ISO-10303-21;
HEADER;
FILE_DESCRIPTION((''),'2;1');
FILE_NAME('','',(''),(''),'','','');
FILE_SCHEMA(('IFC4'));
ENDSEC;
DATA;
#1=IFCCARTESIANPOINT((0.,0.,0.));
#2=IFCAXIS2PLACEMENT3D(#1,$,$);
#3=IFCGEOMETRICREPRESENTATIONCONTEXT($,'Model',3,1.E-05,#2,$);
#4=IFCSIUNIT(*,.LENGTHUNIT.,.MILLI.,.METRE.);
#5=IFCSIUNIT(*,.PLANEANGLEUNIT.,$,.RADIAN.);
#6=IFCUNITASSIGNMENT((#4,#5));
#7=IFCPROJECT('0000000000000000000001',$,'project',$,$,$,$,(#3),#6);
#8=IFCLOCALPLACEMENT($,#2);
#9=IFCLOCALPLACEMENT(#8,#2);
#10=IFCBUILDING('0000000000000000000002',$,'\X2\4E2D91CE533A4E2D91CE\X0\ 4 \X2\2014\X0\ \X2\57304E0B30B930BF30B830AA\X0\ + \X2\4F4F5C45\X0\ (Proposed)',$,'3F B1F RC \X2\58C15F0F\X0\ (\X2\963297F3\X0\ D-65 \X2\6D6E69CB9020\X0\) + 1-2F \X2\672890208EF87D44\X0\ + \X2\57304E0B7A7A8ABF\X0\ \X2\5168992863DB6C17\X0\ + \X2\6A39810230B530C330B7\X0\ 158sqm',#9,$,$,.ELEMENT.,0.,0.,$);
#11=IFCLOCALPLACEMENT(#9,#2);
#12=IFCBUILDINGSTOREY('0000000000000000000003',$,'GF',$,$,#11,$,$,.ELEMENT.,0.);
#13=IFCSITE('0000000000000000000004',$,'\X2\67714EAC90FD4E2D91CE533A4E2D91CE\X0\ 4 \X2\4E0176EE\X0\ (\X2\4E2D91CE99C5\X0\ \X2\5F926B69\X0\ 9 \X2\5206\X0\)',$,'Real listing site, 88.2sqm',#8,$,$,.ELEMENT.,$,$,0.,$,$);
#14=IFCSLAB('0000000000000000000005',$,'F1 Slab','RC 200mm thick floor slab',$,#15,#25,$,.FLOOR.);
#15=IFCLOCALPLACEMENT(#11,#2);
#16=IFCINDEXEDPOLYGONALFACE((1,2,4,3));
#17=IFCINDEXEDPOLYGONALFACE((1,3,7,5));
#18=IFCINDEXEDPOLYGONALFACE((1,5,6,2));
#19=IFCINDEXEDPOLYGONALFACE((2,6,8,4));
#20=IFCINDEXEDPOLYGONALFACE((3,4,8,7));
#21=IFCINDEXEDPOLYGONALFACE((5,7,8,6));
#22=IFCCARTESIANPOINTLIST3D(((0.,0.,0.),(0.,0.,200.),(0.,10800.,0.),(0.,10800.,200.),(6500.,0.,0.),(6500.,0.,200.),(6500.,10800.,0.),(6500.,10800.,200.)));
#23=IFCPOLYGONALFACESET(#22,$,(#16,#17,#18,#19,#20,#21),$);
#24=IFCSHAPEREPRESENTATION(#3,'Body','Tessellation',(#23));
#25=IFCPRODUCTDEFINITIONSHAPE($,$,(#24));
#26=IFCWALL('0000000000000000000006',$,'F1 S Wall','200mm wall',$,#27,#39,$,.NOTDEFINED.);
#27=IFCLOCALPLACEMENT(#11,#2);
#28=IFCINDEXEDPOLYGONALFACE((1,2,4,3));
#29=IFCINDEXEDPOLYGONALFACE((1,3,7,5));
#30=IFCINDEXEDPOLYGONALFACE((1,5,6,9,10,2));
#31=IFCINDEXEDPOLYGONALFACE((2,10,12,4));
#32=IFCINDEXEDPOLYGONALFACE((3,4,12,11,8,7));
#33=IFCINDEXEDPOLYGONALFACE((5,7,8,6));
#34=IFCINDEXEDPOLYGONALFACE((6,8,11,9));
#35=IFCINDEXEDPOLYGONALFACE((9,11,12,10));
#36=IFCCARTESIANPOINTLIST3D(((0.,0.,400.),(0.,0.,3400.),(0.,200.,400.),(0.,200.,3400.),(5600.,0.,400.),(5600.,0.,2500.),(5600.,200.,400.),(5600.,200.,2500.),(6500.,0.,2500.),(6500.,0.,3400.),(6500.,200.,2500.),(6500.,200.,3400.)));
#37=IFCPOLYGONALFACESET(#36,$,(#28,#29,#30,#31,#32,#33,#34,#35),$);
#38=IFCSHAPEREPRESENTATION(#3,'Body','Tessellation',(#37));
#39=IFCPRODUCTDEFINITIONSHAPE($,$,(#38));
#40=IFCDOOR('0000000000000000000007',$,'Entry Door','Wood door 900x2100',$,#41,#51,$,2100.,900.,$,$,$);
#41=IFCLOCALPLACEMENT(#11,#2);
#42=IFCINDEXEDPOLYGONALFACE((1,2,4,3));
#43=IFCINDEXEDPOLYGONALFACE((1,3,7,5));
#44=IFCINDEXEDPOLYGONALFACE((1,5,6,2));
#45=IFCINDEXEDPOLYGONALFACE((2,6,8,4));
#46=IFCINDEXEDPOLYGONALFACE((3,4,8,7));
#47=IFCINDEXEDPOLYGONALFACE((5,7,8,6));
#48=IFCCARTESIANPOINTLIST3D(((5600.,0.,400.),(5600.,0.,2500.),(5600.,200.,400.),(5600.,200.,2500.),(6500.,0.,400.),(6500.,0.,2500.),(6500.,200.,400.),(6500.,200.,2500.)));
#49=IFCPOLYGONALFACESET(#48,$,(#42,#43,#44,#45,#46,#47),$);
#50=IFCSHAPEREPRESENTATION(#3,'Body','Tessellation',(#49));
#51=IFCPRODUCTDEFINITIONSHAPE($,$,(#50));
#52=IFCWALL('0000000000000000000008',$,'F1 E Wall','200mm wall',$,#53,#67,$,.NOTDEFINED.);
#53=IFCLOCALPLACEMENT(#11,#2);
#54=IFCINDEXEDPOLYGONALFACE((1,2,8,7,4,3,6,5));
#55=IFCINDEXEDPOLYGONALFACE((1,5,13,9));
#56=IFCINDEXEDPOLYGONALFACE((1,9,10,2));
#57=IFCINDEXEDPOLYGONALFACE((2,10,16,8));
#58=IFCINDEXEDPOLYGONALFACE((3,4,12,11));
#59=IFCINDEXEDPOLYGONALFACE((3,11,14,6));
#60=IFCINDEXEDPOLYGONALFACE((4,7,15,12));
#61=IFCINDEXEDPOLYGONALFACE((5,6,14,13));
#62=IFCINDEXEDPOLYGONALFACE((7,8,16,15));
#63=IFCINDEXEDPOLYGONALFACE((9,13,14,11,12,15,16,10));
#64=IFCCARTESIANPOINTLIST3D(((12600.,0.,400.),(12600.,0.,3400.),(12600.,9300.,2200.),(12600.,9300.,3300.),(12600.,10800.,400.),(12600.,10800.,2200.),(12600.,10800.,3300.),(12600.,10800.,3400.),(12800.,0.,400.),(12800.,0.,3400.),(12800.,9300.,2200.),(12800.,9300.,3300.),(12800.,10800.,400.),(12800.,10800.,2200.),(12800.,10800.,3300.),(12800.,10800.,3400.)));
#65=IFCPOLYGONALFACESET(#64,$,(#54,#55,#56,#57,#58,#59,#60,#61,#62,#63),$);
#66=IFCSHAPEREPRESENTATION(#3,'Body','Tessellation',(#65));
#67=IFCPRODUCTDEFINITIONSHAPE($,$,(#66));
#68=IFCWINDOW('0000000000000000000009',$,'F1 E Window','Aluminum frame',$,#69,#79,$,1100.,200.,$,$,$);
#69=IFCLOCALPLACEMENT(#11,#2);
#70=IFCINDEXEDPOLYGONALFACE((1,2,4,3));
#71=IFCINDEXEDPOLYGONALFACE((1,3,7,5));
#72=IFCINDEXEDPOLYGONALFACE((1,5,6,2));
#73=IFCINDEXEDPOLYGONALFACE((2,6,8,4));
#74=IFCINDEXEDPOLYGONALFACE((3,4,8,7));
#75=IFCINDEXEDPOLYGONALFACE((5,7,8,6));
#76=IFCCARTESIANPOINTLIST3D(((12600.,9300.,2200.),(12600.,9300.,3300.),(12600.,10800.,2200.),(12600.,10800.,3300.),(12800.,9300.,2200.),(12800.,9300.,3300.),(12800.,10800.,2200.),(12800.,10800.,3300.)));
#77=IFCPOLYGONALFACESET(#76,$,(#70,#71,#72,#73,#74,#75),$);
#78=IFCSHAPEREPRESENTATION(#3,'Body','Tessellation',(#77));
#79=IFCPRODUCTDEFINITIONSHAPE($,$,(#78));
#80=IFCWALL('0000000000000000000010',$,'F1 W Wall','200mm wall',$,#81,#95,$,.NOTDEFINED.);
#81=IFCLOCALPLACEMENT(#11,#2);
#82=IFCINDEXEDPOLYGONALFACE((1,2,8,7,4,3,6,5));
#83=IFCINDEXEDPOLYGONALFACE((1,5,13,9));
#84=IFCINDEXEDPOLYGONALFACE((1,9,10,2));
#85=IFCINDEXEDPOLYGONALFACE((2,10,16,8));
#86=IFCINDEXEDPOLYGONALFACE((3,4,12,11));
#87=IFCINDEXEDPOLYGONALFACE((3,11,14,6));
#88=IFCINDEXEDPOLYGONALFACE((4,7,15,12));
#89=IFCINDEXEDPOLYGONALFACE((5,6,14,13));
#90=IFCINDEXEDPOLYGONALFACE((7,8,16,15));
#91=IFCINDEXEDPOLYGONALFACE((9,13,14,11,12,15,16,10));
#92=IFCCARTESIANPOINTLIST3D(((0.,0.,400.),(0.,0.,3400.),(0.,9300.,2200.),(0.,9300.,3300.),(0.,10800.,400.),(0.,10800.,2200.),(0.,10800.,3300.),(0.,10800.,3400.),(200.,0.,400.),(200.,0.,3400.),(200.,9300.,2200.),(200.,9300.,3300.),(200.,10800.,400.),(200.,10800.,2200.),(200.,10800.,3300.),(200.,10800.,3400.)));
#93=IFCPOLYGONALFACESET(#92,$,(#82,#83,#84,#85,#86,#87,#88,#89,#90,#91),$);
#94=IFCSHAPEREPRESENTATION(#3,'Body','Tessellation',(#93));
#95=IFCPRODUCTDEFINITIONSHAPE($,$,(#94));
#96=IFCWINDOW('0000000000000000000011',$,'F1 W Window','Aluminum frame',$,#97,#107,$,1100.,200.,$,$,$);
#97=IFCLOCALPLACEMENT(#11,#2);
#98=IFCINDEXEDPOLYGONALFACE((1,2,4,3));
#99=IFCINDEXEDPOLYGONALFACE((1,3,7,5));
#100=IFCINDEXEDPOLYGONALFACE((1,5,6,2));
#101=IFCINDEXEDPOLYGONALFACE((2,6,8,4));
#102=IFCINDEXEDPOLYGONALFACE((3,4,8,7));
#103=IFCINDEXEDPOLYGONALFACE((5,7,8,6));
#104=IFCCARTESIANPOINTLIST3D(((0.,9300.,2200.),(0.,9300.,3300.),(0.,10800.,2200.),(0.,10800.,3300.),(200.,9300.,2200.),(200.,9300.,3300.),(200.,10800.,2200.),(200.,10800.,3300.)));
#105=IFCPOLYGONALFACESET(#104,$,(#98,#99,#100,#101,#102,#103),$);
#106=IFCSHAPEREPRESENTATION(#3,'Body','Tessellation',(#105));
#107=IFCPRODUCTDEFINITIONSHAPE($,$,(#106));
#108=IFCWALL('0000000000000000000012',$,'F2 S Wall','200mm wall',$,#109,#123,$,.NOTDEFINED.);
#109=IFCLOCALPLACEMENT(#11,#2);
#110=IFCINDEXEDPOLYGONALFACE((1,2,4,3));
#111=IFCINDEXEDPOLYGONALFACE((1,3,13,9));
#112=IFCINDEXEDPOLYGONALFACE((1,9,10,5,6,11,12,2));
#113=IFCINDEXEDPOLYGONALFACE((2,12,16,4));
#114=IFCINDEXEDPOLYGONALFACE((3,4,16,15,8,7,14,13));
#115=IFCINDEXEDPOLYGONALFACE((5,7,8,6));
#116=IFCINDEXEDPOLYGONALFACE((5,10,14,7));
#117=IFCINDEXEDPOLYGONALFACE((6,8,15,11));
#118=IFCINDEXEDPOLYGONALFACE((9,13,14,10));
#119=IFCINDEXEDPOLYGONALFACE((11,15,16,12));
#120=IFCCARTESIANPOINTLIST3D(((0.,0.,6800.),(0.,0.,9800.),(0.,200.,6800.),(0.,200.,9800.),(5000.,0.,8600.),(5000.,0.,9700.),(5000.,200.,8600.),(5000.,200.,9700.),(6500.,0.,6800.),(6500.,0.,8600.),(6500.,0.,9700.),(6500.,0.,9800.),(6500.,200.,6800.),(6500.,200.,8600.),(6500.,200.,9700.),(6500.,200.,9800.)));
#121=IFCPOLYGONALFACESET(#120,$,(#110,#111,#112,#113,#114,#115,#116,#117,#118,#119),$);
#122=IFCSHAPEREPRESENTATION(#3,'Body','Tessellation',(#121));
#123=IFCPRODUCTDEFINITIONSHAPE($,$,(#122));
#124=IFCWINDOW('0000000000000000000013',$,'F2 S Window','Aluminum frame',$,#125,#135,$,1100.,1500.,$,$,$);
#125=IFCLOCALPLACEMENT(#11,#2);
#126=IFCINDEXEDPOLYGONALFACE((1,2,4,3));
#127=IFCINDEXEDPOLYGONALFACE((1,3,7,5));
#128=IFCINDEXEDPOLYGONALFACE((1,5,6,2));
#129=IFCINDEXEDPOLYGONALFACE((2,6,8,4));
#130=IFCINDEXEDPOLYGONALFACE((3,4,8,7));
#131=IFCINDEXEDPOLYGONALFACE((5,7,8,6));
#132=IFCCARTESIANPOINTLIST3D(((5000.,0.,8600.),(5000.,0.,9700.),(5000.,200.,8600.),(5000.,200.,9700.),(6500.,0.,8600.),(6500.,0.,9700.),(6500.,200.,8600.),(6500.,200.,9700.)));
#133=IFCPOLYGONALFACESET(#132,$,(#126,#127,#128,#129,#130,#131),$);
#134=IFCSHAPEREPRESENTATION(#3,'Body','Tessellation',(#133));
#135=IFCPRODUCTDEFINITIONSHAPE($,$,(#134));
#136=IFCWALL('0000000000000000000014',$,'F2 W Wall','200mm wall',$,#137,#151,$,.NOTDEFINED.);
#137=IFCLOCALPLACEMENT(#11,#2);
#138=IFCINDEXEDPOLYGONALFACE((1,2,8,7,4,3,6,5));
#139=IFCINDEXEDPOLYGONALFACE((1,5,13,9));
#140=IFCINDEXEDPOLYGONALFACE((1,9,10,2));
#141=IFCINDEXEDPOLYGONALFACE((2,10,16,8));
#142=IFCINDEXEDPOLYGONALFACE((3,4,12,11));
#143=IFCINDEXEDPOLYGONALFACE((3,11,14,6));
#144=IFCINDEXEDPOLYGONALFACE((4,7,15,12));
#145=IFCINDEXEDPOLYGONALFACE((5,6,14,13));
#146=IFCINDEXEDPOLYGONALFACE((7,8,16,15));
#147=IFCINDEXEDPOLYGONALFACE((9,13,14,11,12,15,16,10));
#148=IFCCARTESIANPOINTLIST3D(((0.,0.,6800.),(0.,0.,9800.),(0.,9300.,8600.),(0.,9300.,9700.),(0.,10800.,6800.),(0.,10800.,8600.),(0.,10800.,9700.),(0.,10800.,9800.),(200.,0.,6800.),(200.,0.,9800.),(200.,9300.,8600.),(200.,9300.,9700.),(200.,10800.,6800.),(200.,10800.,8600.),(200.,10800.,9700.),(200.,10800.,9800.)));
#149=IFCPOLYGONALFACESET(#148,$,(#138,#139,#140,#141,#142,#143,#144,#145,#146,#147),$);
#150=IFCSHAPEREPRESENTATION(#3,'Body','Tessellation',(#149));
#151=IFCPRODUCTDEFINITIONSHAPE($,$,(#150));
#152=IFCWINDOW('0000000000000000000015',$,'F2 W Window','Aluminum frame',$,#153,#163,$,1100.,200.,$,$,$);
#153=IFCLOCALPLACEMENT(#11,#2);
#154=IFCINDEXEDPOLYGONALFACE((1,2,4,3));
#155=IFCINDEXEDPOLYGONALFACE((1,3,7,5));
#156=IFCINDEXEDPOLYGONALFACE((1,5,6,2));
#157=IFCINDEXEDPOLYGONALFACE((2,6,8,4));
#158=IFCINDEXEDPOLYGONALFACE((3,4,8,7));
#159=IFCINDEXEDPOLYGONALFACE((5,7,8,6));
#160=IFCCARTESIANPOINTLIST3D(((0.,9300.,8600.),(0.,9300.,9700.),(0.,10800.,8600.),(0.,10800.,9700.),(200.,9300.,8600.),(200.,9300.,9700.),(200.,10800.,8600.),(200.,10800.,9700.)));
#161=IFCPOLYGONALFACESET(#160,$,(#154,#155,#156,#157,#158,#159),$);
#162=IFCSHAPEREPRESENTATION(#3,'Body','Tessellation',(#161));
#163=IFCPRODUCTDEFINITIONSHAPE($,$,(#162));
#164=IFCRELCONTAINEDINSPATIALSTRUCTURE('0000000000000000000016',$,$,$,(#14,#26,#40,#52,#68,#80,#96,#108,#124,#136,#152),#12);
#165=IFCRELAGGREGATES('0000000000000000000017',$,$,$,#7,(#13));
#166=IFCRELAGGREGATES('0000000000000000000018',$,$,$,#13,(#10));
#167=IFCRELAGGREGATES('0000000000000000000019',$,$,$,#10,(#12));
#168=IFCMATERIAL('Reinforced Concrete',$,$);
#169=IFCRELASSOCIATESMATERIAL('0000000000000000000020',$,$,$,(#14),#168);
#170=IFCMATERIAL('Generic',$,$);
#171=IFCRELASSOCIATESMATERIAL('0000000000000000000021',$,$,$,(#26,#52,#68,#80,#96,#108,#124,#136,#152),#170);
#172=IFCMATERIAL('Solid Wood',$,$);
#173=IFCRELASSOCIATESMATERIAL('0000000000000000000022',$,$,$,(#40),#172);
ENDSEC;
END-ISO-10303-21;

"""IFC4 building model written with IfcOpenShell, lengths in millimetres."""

from ifc_helpers import new_model, si_unit, frame, frame_2d, origin, place, context, project, spatial, rectangle, extrude, material, element, fill, save


model = new_model("IFC4")

# Units and contexts
model_context = context("Model", 3, precision=1e-05, world=origin())
ifc_project = project(units=[si_unit("LENGTHUNIT", "METRE", prefix="MILLI"), si_unit("PLANEANGLEUNIT", "RADIAN")], contexts=[model_context])

# Site, building, storey
site_placement = place(None, origin())
site = spatial("IfcSite", under=ifc_project, at=site_placement, Name="東京都中野区中野 4 丁目 (中野駅 徒歩 9 分)", ObjectType="Real listing site, 88.2sqm", CompositionType="ELEMENT", RefElevation=0.0)
building_placement = place(site_placement, origin())
building = spatial("IfcBuilding", under=site, at=building_placement, Name="中野区中野 4 — 地下スタジオ + 住居 (Proposed)", ObjectType="3F B1F RC 壁式 (防音 D-65 浮構造) + 1-2F 木造軸組 + 地下空調 全館換気 + 樹脂サッシ 158sqm", CompositionType="ELEMENT", ElevationOfRefHeight=0.0, ElevationOfTerrain=0.0)
storey_placement = place(building_placement, origin())
storey = spatial("IfcBuildingStorey", under=building, at=storey_placement, Name="GF", CompositionType="ELEMENT", Elevation=0.0)

# Slab
ifc_material_1 = material(Name="Reinforced Concrete")
slab_1_placement = place(storey_placement, origin())
element("IfcSlab", 1, at=slab_1_placement, inside=storey, material=ifc_material_1, Name="F1 Slab", Description="RC 200mm thick floor slab", PredefinedType="FLOOR", context=model_context, shape_type="SweptSolid", body=[
    extrude(rectangle(XDim=6500.0, YDim=10800.0, at=frame_2d((3250.0, 5400.0))), origin(), (0.0, 0.0, 1.0), 200.0),
])

# Wall, opening, door
ifc_material_2 = material(Name="Generic")
wall_1_placement = place(storey_placement, frame((0.0, 0.0, 200.0)))
wall_1 = element("IfcWall", 2, at=wall_1_placement, inside=storey, material=ifc_material_2, Name="F1 S Wall", Description="200mm wall", PredefinedType="NOTDEFINED", context=model_context, shape_type="SweptSolid", body=[
    extrude(rectangle(XDim=6500.0, YDim=200.0, at=frame_2d((3250.0, 100.0))), frame((0.0, 0.0, 200.0)), (0.0, 0.0, 1.0), 3000.0),
])
opening_1_placement = place(storey_placement, frame((2800.0, 0.0, 200.0)))
opening_1 = element("IfcOpeningElement", 3, at=opening_1_placement, cuts=wall_1, PredefinedType="NOTDEFINED", context=model_context, shape_type="SweptSolid", body=[
    extrude(rectangle(XDim=900.0, YDim=200.0, at=frame_2d((450.0, 100.0))), frame((2800.0, 0.0, 200.0)), (0.0, 0.0, 1.0), 2100.0),
])
ifc_material_3 = material(Name="Solid Wood")
door_placement = place(storey_placement, frame((2800.0, 0.0, 200.0)))
door = element("IfcDoor", 4, at=door_placement, inside=storey, material=ifc_material_3, Name="Entry Door", Description="Wood door 900x2100", OverallHeight=2100.0, OverallWidth=900.0, context=model_context, shape_type="SweptSolid", body=[
    extrude(rectangle(XDim=900.0, YDim=200.0, at=frame_2d((450.0, 100.0))), frame((2800.0, 0.0, 200.0)), (0.0, 0.0, 1.0), 2100.0),
])
fill(opening_1, door)

# Walls, openings, windows
wall_2_placement = place(storey_placement, frame((6300.0, 0.0, 200.0)))
wall_2 = element("IfcWall", 5, at=wall_2_placement, inside=storey, material=ifc_material_2, Name="F1 E Wall", Description="200mm wall", PredefinedType="NOTDEFINED", context=model_context, shape_type="SweptSolid", body=[
    extrude(rectangle(XDim=200.0, YDim=10800.0, at=frame_2d((100.0, 5400.0))), frame((6300.0, 0.0, 200.0)), (0.0, 0.0, 1.0), 3000.0),
])
opening_2_placement = place(storey_placement, frame((6300.0, 4650.0, 1100.0)))
opening_2 = element("IfcOpeningElement", 6, at=opening_2_placement, cuts=wall_2, PredefinedType="NOTDEFINED", context=model_context, shape_type="SweptSolid", body=[
    extrude(rectangle(XDim=200.0, YDim=1500.0, at=frame_2d((100.0, 750.0))), frame((6300.0, 4650.0, 1100.0)), (0.0, 0.0, 1.0), 1100.0),
])
window_1_placement = place(storey_placement, frame((6300.0, 4650.0, 1100.0)))
window_1 = element("IfcWindow", 7, at=window_1_placement, inside=storey, material=ifc_material_2, Name="F1 E Window", Description="Aluminum frame", OverallHeight=1100.0, OverallWidth=200.0, context=model_context, shape_type="SweptSolid", body=[
    extrude(rectangle(XDim=200.0, YDim=1500.0, at=frame_2d((100.0, 750.0))), frame((6300.0, 4650.0, 1100.0)), (0.0, 0.0, 1.0), 1100.0),
])
fill(opening_2, window_1)
wall_3_placement = place(storey_placement, frame((0.0, 0.0, 200.0)))
wall_3 = element("IfcWall", 8, at=wall_3_placement, inside=storey, material=ifc_material_2, Name="F1 W Wall", Description="200mm wall", PredefinedType="NOTDEFINED", context=model_context, shape_type="SweptSolid", body=[
    extrude(rectangle(XDim=200.0, YDim=10800.0, at=frame_2d((100.0, 5400.0))), frame((0.0, 0.0, 200.0)), (0.0, 0.0, 1.0), 3000.0),
])
opening_3_placement = place(storey_placement, frame((0.0, 4650.0, 1100.0)))
opening_3 = element("IfcOpeningElement", 9, at=opening_3_placement, cuts=wall_3, PredefinedType="NOTDEFINED", context=model_context, shape_type="SweptSolid", body=[
    extrude(rectangle(XDim=200.0, YDim=1500.0, at=frame_2d((100.0, 750.0))), frame((0.0, 4650.0, 1100.0)), (0.0, 0.0, 1.0), 1100.0),
])
window_2_placement = place(storey_placement, frame((0.0, 4650.0, 1100.0)))
window_2 = element("IfcWindow", 10, at=window_2_placement, inside=storey, material=ifc_material_2, Name="F1 W Window", Description="Aluminum frame", OverallHeight=1100.0, OverallWidth=200.0, context=model_context, shape_type="SweptSolid", body=[
    extrude(rectangle(XDim=200.0, YDim=1500.0, at=frame_2d((100.0, 750.0))), frame((0.0, 4650.0, 1100.0)), (0.0, 0.0, 1.0), 1100.0),
])
fill(opening_3, window_2)
wall_4_placement = place(storey_placement, frame((0.0, 0.0, 3400.0)))
wall_4 = element("IfcWall", 11, at=wall_4_placement, inside=storey, material=ifc_material_2, Name="F2 S Wall", Description="200mm wall", PredefinedType="NOTDEFINED", context=model_context, shape_type="SweptSolid", body=[
    extrude(rectangle(XDim=6500.0, YDim=200.0, at=frame_2d((3250.0, 100.0))), frame((0.0, 0.0, 3400.0)), (0.0, 0.0, 1.0), 3000.0),
])
opening_4_placement = place(storey_placement, frame((2500.0, 0.0, 4300.0)))
opening_4 = element("IfcOpeningElement", 12, at=opening_4_placement, cuts=wall_4, PredefinedType="NOTDEFINED", context=model_context, shape_type="SweptSolid", body=[
    extrude(rectangle(XDim=1500.0, YDim=200.0, at=frame_2d((750.0, 100.0))), frame((2500.0, 0.0, 4300.0)), (0.0, 0.0, 1.0), 1100.0),
])
window_3_placement = place(storey_placement, frame((2500.0, 0.0, 4300.0)))
window_3 = element("IfcWindow", 13, at=window_3_placement, inside=storey, material=ifc_material_2, Name="F2 S Window", Description="Aluminum frame", OverallHeight=1100.0, OverallWidth=1500.0, context=model_context, shape_type="SweptSolid", body=[
    extrude(rectangle(XDim=1500.0, YDim=200.0, at=frame_2d((750.0, 100.0))), frame((2500.0, 0.0, 4300.0)), (0.0, 0.0, 1.0), 1100.0),
])
fill(opening_4, window_3)
wall_5_placement = place(storey_placement, frame((0.0, 0.0, 3400.0)))
wall_5 = element("IfcWall", 14, at=wall_5_placement, inside=storey, material=ifc_material_2, Name="F2 W Wall", Description="200mm wall", PredefinedType="NOTDEFINED", context=model_context, shape_type="SweptSolid", body=[
    extrude(rectangle(XDim=200.0, YDim=10800.0, at=frame_2d((100.0, 5400.0))), frame((0.0, 0.0, 3400.0)), (0.0, 0.0, 1.0), 3000.0),
])
opening_5_placement = place(storey_placement, frame((0.0, 4650.0, 4300.0)))
opening_5 = element("IfcOpeningElement", 15, at=opening_5_placement, cuts=wall_5, PredefinedType="NOTDEFINED", context=model_context, shape_type="SweptSolid", body=[
    extrude(rectangle(XDim=200.0, YDim=1500.0, at=frame_2d((100.0, 750.0))), frame((0.0, 4650.0, 4300.0)), (0.0, 0.0, 1.0), 1100.0),
])
window_4_placement = place(storey_placement, frame((0.0, 4650.0, 4300.0)))
window_4 = element("IfcWindow", 16, at=window_4_placement, inside=storey, material=ifc_material_2, Name="F2 W Window", Description="Aluminum frame", OverallHeight=1100.0, OverallWidth=200.0, context=model_context, shape_type="SweptSolid", body=[
    extrude(rectangle(XDim=200.0, YDim=1500.0, at=frame_2d((100.0, 750.0))), frame((0.0, 4650.0, 4300.0)), (0.0, 0.0, 1.0), 1100.0),
])
fill(opening_5, window_4)

save(model, "model.ifc")
